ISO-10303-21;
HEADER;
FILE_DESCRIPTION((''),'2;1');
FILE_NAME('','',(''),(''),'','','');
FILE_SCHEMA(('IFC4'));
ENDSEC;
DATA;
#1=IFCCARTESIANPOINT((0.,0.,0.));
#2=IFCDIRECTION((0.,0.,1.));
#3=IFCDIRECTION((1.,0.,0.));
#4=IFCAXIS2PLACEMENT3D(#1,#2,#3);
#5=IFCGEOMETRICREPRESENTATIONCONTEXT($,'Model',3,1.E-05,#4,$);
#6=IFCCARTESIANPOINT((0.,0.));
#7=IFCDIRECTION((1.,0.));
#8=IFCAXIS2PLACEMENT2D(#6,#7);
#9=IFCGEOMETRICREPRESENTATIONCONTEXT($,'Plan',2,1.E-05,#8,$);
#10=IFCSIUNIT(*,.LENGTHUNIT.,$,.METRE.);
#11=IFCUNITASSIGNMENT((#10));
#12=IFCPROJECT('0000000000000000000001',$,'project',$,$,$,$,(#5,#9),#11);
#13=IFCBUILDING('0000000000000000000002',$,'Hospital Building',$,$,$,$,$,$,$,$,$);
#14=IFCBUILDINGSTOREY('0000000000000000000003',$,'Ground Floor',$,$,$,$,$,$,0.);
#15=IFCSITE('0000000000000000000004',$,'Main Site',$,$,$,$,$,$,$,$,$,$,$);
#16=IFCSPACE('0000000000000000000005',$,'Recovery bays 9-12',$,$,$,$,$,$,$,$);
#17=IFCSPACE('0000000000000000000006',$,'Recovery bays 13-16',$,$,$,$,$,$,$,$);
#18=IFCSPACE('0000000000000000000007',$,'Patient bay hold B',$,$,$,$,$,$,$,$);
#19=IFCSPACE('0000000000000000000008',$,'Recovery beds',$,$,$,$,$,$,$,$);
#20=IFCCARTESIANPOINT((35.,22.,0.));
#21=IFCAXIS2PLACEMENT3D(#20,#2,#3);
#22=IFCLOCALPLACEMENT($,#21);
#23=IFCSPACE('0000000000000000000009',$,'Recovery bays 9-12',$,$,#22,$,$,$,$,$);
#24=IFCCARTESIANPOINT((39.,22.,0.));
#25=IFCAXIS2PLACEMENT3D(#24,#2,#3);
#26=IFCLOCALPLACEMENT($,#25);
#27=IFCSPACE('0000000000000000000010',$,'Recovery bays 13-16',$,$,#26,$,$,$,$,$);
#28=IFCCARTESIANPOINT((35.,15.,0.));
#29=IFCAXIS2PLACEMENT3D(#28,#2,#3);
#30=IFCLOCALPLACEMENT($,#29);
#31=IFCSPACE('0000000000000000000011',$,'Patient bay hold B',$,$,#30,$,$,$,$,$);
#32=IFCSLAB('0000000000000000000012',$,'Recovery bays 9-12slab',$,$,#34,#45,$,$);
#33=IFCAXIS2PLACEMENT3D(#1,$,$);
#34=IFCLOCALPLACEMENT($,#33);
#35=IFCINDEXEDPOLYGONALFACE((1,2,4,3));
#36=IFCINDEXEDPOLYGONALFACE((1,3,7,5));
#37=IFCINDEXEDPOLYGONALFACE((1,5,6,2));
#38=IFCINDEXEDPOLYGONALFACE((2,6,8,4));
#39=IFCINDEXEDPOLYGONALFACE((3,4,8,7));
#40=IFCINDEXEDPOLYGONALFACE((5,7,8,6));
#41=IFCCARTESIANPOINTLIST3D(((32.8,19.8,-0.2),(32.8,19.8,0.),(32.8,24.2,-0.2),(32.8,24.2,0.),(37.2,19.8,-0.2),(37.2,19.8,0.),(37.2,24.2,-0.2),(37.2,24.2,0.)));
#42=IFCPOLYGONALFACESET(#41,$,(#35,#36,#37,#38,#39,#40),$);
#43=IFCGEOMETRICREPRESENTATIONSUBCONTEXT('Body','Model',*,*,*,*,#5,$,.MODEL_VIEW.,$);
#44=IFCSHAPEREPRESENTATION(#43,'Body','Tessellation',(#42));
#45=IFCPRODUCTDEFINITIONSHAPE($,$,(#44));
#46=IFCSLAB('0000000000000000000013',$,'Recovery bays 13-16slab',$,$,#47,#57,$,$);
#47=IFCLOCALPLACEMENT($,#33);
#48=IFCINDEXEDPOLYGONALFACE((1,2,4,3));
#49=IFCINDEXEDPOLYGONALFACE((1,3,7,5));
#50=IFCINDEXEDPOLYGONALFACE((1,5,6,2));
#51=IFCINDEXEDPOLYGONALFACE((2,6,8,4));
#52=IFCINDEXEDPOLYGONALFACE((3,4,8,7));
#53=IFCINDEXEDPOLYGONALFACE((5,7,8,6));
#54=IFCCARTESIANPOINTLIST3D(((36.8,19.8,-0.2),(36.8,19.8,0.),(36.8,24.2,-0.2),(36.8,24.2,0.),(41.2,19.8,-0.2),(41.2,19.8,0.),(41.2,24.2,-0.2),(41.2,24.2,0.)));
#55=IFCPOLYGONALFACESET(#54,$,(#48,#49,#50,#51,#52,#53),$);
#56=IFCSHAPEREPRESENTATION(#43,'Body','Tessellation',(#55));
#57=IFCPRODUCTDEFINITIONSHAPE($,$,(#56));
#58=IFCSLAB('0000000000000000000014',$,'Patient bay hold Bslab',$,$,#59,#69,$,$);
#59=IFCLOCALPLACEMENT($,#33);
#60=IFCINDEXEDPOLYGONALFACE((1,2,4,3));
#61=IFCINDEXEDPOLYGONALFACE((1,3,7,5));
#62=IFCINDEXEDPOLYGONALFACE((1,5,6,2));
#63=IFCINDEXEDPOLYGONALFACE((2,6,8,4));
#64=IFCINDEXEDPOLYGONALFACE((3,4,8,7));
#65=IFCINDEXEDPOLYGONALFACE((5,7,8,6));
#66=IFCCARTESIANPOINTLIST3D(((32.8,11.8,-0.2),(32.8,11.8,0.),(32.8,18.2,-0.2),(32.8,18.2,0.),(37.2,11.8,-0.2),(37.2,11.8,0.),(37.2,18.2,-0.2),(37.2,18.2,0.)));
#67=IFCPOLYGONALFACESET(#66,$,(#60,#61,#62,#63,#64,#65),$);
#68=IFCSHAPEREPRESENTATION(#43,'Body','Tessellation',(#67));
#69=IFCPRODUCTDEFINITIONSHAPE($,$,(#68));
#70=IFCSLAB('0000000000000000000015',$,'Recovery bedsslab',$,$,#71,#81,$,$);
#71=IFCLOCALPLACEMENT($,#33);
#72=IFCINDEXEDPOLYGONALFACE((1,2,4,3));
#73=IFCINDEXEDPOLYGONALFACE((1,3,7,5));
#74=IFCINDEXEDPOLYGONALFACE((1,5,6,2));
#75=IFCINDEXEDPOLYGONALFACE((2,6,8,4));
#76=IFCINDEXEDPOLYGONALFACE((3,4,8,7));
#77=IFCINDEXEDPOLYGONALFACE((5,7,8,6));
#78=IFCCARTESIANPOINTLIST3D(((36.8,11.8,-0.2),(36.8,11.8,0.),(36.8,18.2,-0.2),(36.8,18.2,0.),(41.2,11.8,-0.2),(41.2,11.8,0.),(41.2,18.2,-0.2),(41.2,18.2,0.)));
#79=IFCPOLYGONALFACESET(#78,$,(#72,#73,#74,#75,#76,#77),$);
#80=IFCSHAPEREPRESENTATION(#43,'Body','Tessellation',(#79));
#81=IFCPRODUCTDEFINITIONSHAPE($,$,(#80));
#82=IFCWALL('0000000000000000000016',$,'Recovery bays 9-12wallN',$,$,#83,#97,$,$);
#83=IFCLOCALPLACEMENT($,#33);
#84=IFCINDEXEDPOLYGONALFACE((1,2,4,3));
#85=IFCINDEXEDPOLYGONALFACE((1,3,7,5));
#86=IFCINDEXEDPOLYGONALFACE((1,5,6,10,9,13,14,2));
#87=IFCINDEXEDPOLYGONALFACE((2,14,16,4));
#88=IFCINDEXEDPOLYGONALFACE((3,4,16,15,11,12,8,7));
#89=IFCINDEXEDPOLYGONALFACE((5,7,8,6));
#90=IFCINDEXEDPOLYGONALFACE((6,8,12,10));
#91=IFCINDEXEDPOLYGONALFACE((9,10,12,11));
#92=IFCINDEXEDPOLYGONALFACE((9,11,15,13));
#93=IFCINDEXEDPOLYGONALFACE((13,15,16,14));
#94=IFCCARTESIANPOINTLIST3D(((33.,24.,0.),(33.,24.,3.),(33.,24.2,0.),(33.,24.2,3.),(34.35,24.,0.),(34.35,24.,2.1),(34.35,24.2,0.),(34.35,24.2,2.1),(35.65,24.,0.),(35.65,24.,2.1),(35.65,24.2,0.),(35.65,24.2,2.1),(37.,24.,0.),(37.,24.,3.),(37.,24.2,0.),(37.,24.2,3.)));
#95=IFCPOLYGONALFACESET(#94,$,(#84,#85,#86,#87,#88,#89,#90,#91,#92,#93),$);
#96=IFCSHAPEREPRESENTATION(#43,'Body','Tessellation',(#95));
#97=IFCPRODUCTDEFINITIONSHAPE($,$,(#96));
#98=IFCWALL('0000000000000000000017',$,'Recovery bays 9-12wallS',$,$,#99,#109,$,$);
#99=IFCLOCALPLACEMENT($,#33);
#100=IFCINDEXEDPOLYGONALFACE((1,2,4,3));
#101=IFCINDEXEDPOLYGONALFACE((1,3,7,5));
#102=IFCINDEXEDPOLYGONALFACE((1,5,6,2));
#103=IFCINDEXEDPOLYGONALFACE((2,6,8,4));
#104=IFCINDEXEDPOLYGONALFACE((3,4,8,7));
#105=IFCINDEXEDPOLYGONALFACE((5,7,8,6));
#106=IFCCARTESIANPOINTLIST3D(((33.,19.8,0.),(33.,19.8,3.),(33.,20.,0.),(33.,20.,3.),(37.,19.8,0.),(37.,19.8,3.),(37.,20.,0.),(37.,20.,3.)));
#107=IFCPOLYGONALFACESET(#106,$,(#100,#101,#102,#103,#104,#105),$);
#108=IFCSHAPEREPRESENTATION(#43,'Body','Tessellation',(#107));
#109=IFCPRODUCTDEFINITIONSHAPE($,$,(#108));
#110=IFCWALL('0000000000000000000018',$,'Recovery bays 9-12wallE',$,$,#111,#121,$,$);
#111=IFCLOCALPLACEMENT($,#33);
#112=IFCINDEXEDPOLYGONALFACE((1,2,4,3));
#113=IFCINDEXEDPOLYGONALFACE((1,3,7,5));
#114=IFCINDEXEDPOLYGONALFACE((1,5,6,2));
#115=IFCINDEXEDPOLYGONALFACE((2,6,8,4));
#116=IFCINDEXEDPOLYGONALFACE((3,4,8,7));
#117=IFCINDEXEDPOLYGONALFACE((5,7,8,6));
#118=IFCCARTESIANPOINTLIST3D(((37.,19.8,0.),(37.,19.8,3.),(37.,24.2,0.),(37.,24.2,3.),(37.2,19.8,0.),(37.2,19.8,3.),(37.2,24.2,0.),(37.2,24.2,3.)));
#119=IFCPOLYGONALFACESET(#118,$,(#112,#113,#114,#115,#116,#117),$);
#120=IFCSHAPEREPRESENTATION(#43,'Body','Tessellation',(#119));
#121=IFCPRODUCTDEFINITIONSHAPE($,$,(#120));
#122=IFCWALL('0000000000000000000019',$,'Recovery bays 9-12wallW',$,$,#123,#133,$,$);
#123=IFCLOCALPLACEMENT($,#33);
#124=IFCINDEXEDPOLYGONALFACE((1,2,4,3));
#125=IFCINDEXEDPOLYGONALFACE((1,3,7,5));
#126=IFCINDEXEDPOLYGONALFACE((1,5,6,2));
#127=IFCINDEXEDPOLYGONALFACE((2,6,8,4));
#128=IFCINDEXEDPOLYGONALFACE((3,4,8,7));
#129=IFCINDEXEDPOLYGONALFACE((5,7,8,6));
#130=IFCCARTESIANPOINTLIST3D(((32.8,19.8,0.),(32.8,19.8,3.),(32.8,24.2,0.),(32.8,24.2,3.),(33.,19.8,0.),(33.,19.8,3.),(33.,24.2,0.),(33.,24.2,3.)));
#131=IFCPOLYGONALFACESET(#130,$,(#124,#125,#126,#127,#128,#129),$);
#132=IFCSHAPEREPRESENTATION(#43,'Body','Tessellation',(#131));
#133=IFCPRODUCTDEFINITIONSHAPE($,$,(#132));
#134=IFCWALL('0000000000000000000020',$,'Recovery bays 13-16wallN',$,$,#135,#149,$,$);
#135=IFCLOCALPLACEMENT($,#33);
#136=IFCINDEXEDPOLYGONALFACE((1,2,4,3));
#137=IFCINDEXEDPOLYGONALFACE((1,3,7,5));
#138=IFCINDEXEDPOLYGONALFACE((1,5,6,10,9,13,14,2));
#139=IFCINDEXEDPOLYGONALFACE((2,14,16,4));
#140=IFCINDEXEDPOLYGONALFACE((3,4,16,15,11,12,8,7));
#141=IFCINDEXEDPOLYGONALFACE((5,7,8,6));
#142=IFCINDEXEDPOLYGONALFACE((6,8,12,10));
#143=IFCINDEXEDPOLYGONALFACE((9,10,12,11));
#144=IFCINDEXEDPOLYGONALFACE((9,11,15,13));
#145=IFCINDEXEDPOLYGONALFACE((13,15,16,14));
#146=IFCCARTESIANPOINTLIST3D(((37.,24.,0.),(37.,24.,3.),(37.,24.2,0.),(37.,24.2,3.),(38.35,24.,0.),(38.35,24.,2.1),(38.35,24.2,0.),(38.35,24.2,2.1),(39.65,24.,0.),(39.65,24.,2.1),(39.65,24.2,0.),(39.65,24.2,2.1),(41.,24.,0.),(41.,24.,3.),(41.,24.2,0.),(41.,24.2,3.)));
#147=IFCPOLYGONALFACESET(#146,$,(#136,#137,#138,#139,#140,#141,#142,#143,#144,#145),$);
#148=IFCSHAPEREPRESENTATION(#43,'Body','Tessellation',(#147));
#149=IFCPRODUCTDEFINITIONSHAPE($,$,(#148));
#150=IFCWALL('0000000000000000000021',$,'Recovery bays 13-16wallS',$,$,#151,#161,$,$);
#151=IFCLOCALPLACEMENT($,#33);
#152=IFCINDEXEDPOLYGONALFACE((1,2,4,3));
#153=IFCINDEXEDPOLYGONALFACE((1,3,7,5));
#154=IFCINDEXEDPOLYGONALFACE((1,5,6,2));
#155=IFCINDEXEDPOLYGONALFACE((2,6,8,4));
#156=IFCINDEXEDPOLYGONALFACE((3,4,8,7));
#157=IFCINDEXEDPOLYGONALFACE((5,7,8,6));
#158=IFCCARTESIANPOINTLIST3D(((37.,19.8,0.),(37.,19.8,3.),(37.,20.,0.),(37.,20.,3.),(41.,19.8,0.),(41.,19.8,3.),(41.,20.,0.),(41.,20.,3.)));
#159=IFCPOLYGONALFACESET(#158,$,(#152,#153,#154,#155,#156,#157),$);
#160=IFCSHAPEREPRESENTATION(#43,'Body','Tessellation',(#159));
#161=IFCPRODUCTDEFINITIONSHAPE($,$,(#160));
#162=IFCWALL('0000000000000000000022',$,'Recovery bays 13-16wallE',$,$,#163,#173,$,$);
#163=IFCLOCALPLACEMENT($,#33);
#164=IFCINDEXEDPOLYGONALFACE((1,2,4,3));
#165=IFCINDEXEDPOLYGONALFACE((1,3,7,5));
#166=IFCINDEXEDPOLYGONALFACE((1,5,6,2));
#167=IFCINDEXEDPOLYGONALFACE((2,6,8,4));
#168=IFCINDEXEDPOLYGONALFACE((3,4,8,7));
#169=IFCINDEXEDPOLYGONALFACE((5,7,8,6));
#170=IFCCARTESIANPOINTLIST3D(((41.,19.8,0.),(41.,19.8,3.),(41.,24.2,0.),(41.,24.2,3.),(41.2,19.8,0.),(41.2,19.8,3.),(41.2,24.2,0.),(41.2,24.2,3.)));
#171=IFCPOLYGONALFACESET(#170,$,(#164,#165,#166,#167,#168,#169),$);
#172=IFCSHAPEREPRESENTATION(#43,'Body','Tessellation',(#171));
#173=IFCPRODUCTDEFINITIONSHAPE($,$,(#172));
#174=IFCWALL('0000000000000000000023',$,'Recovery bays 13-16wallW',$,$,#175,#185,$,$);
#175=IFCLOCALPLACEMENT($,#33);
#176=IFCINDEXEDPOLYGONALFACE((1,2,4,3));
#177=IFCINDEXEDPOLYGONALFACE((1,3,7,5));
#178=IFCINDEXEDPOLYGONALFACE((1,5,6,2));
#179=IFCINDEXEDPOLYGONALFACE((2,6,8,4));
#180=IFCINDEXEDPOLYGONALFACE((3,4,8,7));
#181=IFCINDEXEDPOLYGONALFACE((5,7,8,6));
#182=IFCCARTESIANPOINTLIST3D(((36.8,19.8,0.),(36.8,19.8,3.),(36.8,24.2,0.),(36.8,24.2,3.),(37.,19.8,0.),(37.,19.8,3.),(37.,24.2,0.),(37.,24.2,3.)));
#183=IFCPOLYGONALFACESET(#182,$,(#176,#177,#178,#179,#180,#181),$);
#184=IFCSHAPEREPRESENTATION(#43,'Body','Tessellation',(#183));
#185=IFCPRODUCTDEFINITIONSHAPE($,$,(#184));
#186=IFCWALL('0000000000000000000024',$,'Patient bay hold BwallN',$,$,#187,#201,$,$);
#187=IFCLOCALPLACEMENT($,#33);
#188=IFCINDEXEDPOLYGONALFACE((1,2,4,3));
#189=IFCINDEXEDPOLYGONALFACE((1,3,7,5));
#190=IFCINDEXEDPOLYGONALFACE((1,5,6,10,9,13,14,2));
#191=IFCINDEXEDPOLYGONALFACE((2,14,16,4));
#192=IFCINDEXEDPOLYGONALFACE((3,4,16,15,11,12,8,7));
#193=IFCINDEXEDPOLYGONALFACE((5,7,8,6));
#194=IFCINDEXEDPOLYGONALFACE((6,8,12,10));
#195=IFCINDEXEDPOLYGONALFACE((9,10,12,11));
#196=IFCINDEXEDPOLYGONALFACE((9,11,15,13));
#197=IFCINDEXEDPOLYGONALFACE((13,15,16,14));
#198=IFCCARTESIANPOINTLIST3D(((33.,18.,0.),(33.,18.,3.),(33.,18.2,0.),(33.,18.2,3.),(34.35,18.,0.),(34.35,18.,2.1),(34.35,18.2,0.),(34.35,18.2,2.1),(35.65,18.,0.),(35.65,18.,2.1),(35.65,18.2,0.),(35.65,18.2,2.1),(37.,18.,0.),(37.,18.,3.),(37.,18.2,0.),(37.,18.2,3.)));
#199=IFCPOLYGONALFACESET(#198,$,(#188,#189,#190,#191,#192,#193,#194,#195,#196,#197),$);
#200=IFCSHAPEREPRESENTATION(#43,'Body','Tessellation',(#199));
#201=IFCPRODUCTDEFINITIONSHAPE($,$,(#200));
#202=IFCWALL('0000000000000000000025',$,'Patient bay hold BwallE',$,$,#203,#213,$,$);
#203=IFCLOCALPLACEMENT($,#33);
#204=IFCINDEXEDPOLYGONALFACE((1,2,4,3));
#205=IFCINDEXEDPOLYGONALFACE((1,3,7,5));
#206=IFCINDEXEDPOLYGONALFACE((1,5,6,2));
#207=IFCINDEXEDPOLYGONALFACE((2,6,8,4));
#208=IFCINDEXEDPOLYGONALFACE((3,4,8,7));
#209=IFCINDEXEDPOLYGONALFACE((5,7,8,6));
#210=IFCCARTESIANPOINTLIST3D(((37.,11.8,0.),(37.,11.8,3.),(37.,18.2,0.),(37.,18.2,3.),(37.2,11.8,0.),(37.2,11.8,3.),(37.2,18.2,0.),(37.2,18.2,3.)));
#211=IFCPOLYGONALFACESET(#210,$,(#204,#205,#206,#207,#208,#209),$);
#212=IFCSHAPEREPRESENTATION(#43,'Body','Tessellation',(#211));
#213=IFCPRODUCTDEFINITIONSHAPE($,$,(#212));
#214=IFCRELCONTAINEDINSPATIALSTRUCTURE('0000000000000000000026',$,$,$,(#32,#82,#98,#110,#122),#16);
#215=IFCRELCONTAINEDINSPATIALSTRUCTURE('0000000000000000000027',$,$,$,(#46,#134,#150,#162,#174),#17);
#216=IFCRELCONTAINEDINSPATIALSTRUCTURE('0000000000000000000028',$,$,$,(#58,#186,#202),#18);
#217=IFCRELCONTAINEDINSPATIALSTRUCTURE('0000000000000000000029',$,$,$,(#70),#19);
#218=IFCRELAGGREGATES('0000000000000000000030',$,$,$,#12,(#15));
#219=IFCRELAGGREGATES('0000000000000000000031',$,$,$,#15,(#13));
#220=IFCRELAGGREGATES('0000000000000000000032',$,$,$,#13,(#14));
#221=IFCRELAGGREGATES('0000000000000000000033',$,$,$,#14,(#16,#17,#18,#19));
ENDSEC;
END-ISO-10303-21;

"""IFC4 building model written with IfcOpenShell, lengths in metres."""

from ifc_helpers import new_model, si_unit, frame, origin_with_axes, origin_2d_with_axis, place, context, subcontext, project, spatial, indexed_curve, rectangle, outline, extrude, element, save


model = new_model("IFC4")

# Units and contexts
model_context = context("Model", 3, precision=1e-05, world=origin_with_axes())
plan_context = context("Plan", 2, precision=1e-05, world=origin_2d_with_axis())
body_context = subcontext(model_context, "Body", "Model", "MODEL_VIEW")
ifc_project = project(units=[si_unit("LENGTHUNIT", "METRE")], contexts=[model_context, plan_context])

# Site, building, storey, space
site = spatial("IfcSite", under=ifc_project, Name="Main Site")
building = spatial("IfcBuilding", under=site, Name="Hospital Building")
storey = spatial("IfcBuildingStorey", under=building, Name="Ground Floor", Elevation=0.0)
space_1 = spatial("IfcSpace", under=storey, Name="Recovery bays 9-12")

# Slab
slab_1_placement = place(None, frame((35.0, 22.0, -0.2), z_axis=(0.0, 0.0, 1.0), x_axis=(1.0, 0.0, 0.0)))
element("IfcSlab", 1, at=slab_1_placement, inside=space_1, Name="Recovery bays 9-12slab", context=body_context, shape_type="SweptSolid", body=[
    extrude(rectangle(XDim=4.4, YDim=4.4), origin_with_axes(), (0.0, 0.0, 1.0), 0.2),
])

# Shared definitions
space_2 = spatial("IfcSpace", under=storey, Name="Recovery bays 13-16")

# Slab
slab_2_placement = place(None, frame((39.0, 22.0, -0.2), z_axis=(0.0, 0.0, 1.0), x_axis=(1.0, 0.0, 0.0)))
element("IfcSlab", 2, at=slab_2_placement, inside=space_2, Name="Recovery bays 13-16slab", context=body_context, shape_type="SweptSolid", body=[
    extrude(rectangle(XDim=4.4, YDim=4.4), origin_with_axes(), (0.0, 0.0, 1.0), 0.2),
])

# Shared definitions
space_3 = spatial("IfcSpace", under=storey, Name="Patient bay hold B")

# Slab
slab_3_placement = place(None, frame((35.0, 15.0, -0.2), z_axis=(0.0, 0.0, 1.0), x_axis=(1.0, 0.0, 0.0)))
element("IfcSlab", 3, at=slab_3_placement, inside=space_3, Name="Patient bay hold Bslab", context=body_context, shape_type="SweptSolid", body=[
    extrude(rectangle(XDim=4.4, YDim=6.4), origin_with_axes(), (0.0, 0.0, 1.0), 0.2),
])

# Shared definitions
space_4 = spatial("IfcSpace", under=storey, Name="Recovery beds")

# Slab
slab_4_placement = place(None, frame((39.0, 15.0, -0.2), z_axis=(0.0, 0.0, 1.0), x_axis=(1.0, 0.0, 0.0)))
element("IfcSlab", 4, at=slab_4_placement, inside=space_4, Name="Recovery bedsslab", context=body_context, shape_type="SweptSolid", body=[
    extrude(rectangle(XDim=4.4, YDim=6.4), origin_with_axes(), (0.0, 0.0, 1.0), 0.2),
])

# Wall
wall_1_placement = place(None, frame((33.0, 24.0, 0.0), z_axis=(0.0, 0.0, 1.0), x_axis=(1.0, 0.0, 0.0)))
wall_1 = element("IfcWall", 5, at=wall_1_placement, inside=space_1, Name="Recovery bays 9-12wallN", context=body_context, shape_type="SweptSolid", body=[
    extrude(outline(indexed_curve([(0.0, 0.0), (0.0, 0.2), (4.0, 0.2), (4.0, 0.0), (0.0, 0.0)], self_intersect=False)), origin_with_axes(), (0.0, 0.0, 1.0), 3.0),
])

# Shared definitions
space_5_placement = place(None, frame((35.0, 22.0, 0.0), z_axis=(0.0, 0.0, 1.0), x_axis=(1.0, 0.0, 0.0)))
space_5 = spatial("IfcSpace", at=space_5_placement, Name="Recovery bays 9-12")

# Opening
opening_1_placement = place(wall_1_placement, frame((1.35, -0.1, 0.0), z_axis=(0.0, 0.0, 1.0), x_axis=(1.0, 0.0, 0.0)))
element("IfcOpeningElement", 6, at=opening_1_placement, inside=space_5, cuts=wall_1, context=body_context, shape_type="SweptSolid", body=[
    extrude(outline(indexed_curve([(0.0, 0.0), (0.0, 0.4), (1.3, 0.4), (1.3, 0.0), (0.0, 0.0)], self_intersect=False)), origin_with_axes(), (0.0, 0.0, 1.0), 2.1),
])

# Walls
wall_2_placement = place(None, frame((33.0, 19.8, 0.0), z_axis=(0.0, 0.0, 1.0), x_axis=(1.0, 0.0, 0.0)))
element("IfcWall", 7, at=wall_2_placement, inside=space_1, Name="Recovery bays 9-12wallS", context=body_context, shape_type="SweptSolid", body=[
    extrude(outline(indexed_curve([(0.0, 0.0), (0.0, 0.2), (4.0, 0.2), (4.0, 0.0), (0.0, 0.0)], self_intersect=False)), origin_with_axes(), (0.0, 0.0, 1.0), 3.0),
])
for number, where, z_axis, x_axis, name in (
    (8, (37.2, 19.8, 0.0), (0.0, 0.0, 1.0), (0.0, 1.0, 0.0), "Recovery bays 9-12wallE"),
    (9, (33.0, 19.8, 0.0), (0.0, 0.0, 1.0), (0.0, 1.0, 0.0), "Recovery bays 9-12wallW"),
):
    element("IfcWall", number, at=place(None, frame(where, z_axis=z_axis, x_axis=x_axis)), inside=space_1, Name=name, context=body_context, shape_type="SweptSolid", body=[
        extrude(outline(indexed_curve([(0.0, 0.0), (0.0, 0.2), (4.4, 0.2), (4.4, 0.0), (0.0, 0.0)], self_intersect=False)), origin_with_axes(), (0.0, 0.0, 1.0), 3.0),
    ])

# Wall
wall_3_placement = place(None, frame((37.0, 24.0, 0.0), z_axis=(0.0, 0.0, 1.0), x_axis=(1.0, 0.0, 0.0)))
wall_3 = element("IfcWall", 10, at=wall_3_placement, inside=space_2, Name="Recovery bays 13-16wallN", context=body_context, shape_type="SweptSolid", body=[
    extrude(outline(indexed_curve([(0.0, 0.0), (0.0, 0.2), (4.0, 0.2), (4.0, 0.0), (0.0, 0.0)], self_intersect=False)), origin_with_axes(), (0.0, 0.0, 1.0), 3.0),
])

# Shared definitions
space_6_placement = place(None, frame((39.0, 22.0, 0.0), z_axis=(0.0, 0.0, 1.0), x_axis=(1.0, 0.0, 0.0)))
space_6 = spatial("IfcSpace", at=space_6_placement, Name="Recovery bays 13-16")

# Opening
opening_2_placement = place(wall_3_placement, frame((1.35, -0.1, 0.0), z_axis=(0.0, 0.0, 1.0), x_axis=(1.0, 0.0, 0.0)))
element("IfcOpeningElement", 11, at=opening_2_placement, inside=space_6, cuts=wall_3, context=body_context, shape_type="SweptSolid", body=[
    extrude(outline(indexed_curve([(0.0, 0.0), (0.0, 0.4), (1.3, 0.4), (1.3, 0.0), (0.0, 0.0)], self_intersect=False)), origin_with_axes(), (0.0, 0.0, 1.0), 2.1),
])

# Walls
wall_4_placement = place(None, frame((37.0, 19.8, 0.0), z_axis=(0.0, 0.0, 1.0), x_axis=(1.0, 0.0, 0.0)))
element("IfcWall", 12, at=wall_4_placement, inside=space_2, Name="Recovery bays 13-16wallS", context=body_context, shape_type="SweptSolid", body=[
    extrude(outline(indexed_curve([(0.0, 0.0), (0.0, 0.2), (4.0, 0.2), (4.0, 0.0), (0.0, 0.0)], self_intersect=False)), origin_with_axes(), (0.0, 0.0, 1.0), 3.0),
])
for number, where, z_axis, x_axis, name in (
    (13, (41.2, 19.8, 0.0), (0.0, 0.0, 1.0), (0.0, 1.0, 0.0), "Recovery bays 13-16wallE"),
    (14, (37.0, 19.8, 0.0), (0.0, 0.0, 1.0), (0.0, 1.0, 0.0), "Recovery bays 13-16wallW"),
):
    element("IfcWall", number, at=place(None, frame(where, z_axis=z_axis, x_axis=x_axis)), inside=space_2, Name=name, context=body_context, shape_type="SweptSolid", body=[
        extrude(outline(indexed_curve([(0.0, 0.0), (0.0, 0.2), (4.4, 0.2), (4.4, 0.0), (0.0, 0.0)], self_intersect=False)), origin_with_axes(), (0.0, 0.0, 1.0), 3.0),
    ])

# Wall
wall_5_placement = place(None, frame((33.0, 18.0, 0.0), z_axis=(0.0, 0.0, 1.0), x_axis=(1.0, 0.0, 0.0)))
wall_5 = element("IfcWall", 15, at=wall_5_placement, inside=space_3, Name="Patient bay hold BwallN", context=body_context, shape_type="SweptSolid", body=[
    extrude(outline(indexed_curve([(0.0, 0.0), (0.0, 0.2), (4.0, 0.2), (4.0, 0.0), (0.0, 0.0)], self_intersect=False)), origin_with_axes(), (0.0, 0.0, 1.0), 3.0),
])

# Shared definitions
space_7_placement = place(None, frame((35.0, 15.0, 0.0), z_axis=(0.0, 0.0, 1.0), x_axis=(1.0, 0.0, 0.0)))
space_7 = spatial("IfcSpace", at=space_7_placement, Name="Patient bay hold B")

# Opening
opening_3_placement = place(wall_5_placement, frame((1.35, -0.1, 0.0), z_axis=(0.0, 0.0, 1.0), x_axis=(1.0, 0.0, 0.0)))
element("IfcOpeningElement", 16, at=opening_3_placement, inside=space_7, cuts=wall_5, context=body_context, shape_type="SweptSolid", body=[
    extrude(outline(indexed_curve([(0.0, 0.0), (0.0, 0.4), (1.3, 0.4), (1.3, 0.0), (0.0, 0.0)], self_intersect=False)), origin_with_axes(), (0.0, 0.0, 1.0), 2.1),
])

# Wall
wall_6_placement = place(None, frame((37.2, 11.8, 0.0), z_axis=(0.0, 0.0, 1.0), x_axis=(0.0, 1.0, 0.0)))
element("IfcWall", 17, at=wall_6_placement, inside=space_3, Name="Patient bay hold BwallE", context=body_context, shape_type="SweptSolid", body=[
    extrude(outline(indexed_curve([(0.0, 0.0), (0.0, 0.2), (6.4, 0.2), (6.4, 0.0), (0.0, 0.0)], self_intersect=False)), origin_with_axes(), (0.0, 0.0, 1.0), 3.0),
])

save(model, "model.ifc")
